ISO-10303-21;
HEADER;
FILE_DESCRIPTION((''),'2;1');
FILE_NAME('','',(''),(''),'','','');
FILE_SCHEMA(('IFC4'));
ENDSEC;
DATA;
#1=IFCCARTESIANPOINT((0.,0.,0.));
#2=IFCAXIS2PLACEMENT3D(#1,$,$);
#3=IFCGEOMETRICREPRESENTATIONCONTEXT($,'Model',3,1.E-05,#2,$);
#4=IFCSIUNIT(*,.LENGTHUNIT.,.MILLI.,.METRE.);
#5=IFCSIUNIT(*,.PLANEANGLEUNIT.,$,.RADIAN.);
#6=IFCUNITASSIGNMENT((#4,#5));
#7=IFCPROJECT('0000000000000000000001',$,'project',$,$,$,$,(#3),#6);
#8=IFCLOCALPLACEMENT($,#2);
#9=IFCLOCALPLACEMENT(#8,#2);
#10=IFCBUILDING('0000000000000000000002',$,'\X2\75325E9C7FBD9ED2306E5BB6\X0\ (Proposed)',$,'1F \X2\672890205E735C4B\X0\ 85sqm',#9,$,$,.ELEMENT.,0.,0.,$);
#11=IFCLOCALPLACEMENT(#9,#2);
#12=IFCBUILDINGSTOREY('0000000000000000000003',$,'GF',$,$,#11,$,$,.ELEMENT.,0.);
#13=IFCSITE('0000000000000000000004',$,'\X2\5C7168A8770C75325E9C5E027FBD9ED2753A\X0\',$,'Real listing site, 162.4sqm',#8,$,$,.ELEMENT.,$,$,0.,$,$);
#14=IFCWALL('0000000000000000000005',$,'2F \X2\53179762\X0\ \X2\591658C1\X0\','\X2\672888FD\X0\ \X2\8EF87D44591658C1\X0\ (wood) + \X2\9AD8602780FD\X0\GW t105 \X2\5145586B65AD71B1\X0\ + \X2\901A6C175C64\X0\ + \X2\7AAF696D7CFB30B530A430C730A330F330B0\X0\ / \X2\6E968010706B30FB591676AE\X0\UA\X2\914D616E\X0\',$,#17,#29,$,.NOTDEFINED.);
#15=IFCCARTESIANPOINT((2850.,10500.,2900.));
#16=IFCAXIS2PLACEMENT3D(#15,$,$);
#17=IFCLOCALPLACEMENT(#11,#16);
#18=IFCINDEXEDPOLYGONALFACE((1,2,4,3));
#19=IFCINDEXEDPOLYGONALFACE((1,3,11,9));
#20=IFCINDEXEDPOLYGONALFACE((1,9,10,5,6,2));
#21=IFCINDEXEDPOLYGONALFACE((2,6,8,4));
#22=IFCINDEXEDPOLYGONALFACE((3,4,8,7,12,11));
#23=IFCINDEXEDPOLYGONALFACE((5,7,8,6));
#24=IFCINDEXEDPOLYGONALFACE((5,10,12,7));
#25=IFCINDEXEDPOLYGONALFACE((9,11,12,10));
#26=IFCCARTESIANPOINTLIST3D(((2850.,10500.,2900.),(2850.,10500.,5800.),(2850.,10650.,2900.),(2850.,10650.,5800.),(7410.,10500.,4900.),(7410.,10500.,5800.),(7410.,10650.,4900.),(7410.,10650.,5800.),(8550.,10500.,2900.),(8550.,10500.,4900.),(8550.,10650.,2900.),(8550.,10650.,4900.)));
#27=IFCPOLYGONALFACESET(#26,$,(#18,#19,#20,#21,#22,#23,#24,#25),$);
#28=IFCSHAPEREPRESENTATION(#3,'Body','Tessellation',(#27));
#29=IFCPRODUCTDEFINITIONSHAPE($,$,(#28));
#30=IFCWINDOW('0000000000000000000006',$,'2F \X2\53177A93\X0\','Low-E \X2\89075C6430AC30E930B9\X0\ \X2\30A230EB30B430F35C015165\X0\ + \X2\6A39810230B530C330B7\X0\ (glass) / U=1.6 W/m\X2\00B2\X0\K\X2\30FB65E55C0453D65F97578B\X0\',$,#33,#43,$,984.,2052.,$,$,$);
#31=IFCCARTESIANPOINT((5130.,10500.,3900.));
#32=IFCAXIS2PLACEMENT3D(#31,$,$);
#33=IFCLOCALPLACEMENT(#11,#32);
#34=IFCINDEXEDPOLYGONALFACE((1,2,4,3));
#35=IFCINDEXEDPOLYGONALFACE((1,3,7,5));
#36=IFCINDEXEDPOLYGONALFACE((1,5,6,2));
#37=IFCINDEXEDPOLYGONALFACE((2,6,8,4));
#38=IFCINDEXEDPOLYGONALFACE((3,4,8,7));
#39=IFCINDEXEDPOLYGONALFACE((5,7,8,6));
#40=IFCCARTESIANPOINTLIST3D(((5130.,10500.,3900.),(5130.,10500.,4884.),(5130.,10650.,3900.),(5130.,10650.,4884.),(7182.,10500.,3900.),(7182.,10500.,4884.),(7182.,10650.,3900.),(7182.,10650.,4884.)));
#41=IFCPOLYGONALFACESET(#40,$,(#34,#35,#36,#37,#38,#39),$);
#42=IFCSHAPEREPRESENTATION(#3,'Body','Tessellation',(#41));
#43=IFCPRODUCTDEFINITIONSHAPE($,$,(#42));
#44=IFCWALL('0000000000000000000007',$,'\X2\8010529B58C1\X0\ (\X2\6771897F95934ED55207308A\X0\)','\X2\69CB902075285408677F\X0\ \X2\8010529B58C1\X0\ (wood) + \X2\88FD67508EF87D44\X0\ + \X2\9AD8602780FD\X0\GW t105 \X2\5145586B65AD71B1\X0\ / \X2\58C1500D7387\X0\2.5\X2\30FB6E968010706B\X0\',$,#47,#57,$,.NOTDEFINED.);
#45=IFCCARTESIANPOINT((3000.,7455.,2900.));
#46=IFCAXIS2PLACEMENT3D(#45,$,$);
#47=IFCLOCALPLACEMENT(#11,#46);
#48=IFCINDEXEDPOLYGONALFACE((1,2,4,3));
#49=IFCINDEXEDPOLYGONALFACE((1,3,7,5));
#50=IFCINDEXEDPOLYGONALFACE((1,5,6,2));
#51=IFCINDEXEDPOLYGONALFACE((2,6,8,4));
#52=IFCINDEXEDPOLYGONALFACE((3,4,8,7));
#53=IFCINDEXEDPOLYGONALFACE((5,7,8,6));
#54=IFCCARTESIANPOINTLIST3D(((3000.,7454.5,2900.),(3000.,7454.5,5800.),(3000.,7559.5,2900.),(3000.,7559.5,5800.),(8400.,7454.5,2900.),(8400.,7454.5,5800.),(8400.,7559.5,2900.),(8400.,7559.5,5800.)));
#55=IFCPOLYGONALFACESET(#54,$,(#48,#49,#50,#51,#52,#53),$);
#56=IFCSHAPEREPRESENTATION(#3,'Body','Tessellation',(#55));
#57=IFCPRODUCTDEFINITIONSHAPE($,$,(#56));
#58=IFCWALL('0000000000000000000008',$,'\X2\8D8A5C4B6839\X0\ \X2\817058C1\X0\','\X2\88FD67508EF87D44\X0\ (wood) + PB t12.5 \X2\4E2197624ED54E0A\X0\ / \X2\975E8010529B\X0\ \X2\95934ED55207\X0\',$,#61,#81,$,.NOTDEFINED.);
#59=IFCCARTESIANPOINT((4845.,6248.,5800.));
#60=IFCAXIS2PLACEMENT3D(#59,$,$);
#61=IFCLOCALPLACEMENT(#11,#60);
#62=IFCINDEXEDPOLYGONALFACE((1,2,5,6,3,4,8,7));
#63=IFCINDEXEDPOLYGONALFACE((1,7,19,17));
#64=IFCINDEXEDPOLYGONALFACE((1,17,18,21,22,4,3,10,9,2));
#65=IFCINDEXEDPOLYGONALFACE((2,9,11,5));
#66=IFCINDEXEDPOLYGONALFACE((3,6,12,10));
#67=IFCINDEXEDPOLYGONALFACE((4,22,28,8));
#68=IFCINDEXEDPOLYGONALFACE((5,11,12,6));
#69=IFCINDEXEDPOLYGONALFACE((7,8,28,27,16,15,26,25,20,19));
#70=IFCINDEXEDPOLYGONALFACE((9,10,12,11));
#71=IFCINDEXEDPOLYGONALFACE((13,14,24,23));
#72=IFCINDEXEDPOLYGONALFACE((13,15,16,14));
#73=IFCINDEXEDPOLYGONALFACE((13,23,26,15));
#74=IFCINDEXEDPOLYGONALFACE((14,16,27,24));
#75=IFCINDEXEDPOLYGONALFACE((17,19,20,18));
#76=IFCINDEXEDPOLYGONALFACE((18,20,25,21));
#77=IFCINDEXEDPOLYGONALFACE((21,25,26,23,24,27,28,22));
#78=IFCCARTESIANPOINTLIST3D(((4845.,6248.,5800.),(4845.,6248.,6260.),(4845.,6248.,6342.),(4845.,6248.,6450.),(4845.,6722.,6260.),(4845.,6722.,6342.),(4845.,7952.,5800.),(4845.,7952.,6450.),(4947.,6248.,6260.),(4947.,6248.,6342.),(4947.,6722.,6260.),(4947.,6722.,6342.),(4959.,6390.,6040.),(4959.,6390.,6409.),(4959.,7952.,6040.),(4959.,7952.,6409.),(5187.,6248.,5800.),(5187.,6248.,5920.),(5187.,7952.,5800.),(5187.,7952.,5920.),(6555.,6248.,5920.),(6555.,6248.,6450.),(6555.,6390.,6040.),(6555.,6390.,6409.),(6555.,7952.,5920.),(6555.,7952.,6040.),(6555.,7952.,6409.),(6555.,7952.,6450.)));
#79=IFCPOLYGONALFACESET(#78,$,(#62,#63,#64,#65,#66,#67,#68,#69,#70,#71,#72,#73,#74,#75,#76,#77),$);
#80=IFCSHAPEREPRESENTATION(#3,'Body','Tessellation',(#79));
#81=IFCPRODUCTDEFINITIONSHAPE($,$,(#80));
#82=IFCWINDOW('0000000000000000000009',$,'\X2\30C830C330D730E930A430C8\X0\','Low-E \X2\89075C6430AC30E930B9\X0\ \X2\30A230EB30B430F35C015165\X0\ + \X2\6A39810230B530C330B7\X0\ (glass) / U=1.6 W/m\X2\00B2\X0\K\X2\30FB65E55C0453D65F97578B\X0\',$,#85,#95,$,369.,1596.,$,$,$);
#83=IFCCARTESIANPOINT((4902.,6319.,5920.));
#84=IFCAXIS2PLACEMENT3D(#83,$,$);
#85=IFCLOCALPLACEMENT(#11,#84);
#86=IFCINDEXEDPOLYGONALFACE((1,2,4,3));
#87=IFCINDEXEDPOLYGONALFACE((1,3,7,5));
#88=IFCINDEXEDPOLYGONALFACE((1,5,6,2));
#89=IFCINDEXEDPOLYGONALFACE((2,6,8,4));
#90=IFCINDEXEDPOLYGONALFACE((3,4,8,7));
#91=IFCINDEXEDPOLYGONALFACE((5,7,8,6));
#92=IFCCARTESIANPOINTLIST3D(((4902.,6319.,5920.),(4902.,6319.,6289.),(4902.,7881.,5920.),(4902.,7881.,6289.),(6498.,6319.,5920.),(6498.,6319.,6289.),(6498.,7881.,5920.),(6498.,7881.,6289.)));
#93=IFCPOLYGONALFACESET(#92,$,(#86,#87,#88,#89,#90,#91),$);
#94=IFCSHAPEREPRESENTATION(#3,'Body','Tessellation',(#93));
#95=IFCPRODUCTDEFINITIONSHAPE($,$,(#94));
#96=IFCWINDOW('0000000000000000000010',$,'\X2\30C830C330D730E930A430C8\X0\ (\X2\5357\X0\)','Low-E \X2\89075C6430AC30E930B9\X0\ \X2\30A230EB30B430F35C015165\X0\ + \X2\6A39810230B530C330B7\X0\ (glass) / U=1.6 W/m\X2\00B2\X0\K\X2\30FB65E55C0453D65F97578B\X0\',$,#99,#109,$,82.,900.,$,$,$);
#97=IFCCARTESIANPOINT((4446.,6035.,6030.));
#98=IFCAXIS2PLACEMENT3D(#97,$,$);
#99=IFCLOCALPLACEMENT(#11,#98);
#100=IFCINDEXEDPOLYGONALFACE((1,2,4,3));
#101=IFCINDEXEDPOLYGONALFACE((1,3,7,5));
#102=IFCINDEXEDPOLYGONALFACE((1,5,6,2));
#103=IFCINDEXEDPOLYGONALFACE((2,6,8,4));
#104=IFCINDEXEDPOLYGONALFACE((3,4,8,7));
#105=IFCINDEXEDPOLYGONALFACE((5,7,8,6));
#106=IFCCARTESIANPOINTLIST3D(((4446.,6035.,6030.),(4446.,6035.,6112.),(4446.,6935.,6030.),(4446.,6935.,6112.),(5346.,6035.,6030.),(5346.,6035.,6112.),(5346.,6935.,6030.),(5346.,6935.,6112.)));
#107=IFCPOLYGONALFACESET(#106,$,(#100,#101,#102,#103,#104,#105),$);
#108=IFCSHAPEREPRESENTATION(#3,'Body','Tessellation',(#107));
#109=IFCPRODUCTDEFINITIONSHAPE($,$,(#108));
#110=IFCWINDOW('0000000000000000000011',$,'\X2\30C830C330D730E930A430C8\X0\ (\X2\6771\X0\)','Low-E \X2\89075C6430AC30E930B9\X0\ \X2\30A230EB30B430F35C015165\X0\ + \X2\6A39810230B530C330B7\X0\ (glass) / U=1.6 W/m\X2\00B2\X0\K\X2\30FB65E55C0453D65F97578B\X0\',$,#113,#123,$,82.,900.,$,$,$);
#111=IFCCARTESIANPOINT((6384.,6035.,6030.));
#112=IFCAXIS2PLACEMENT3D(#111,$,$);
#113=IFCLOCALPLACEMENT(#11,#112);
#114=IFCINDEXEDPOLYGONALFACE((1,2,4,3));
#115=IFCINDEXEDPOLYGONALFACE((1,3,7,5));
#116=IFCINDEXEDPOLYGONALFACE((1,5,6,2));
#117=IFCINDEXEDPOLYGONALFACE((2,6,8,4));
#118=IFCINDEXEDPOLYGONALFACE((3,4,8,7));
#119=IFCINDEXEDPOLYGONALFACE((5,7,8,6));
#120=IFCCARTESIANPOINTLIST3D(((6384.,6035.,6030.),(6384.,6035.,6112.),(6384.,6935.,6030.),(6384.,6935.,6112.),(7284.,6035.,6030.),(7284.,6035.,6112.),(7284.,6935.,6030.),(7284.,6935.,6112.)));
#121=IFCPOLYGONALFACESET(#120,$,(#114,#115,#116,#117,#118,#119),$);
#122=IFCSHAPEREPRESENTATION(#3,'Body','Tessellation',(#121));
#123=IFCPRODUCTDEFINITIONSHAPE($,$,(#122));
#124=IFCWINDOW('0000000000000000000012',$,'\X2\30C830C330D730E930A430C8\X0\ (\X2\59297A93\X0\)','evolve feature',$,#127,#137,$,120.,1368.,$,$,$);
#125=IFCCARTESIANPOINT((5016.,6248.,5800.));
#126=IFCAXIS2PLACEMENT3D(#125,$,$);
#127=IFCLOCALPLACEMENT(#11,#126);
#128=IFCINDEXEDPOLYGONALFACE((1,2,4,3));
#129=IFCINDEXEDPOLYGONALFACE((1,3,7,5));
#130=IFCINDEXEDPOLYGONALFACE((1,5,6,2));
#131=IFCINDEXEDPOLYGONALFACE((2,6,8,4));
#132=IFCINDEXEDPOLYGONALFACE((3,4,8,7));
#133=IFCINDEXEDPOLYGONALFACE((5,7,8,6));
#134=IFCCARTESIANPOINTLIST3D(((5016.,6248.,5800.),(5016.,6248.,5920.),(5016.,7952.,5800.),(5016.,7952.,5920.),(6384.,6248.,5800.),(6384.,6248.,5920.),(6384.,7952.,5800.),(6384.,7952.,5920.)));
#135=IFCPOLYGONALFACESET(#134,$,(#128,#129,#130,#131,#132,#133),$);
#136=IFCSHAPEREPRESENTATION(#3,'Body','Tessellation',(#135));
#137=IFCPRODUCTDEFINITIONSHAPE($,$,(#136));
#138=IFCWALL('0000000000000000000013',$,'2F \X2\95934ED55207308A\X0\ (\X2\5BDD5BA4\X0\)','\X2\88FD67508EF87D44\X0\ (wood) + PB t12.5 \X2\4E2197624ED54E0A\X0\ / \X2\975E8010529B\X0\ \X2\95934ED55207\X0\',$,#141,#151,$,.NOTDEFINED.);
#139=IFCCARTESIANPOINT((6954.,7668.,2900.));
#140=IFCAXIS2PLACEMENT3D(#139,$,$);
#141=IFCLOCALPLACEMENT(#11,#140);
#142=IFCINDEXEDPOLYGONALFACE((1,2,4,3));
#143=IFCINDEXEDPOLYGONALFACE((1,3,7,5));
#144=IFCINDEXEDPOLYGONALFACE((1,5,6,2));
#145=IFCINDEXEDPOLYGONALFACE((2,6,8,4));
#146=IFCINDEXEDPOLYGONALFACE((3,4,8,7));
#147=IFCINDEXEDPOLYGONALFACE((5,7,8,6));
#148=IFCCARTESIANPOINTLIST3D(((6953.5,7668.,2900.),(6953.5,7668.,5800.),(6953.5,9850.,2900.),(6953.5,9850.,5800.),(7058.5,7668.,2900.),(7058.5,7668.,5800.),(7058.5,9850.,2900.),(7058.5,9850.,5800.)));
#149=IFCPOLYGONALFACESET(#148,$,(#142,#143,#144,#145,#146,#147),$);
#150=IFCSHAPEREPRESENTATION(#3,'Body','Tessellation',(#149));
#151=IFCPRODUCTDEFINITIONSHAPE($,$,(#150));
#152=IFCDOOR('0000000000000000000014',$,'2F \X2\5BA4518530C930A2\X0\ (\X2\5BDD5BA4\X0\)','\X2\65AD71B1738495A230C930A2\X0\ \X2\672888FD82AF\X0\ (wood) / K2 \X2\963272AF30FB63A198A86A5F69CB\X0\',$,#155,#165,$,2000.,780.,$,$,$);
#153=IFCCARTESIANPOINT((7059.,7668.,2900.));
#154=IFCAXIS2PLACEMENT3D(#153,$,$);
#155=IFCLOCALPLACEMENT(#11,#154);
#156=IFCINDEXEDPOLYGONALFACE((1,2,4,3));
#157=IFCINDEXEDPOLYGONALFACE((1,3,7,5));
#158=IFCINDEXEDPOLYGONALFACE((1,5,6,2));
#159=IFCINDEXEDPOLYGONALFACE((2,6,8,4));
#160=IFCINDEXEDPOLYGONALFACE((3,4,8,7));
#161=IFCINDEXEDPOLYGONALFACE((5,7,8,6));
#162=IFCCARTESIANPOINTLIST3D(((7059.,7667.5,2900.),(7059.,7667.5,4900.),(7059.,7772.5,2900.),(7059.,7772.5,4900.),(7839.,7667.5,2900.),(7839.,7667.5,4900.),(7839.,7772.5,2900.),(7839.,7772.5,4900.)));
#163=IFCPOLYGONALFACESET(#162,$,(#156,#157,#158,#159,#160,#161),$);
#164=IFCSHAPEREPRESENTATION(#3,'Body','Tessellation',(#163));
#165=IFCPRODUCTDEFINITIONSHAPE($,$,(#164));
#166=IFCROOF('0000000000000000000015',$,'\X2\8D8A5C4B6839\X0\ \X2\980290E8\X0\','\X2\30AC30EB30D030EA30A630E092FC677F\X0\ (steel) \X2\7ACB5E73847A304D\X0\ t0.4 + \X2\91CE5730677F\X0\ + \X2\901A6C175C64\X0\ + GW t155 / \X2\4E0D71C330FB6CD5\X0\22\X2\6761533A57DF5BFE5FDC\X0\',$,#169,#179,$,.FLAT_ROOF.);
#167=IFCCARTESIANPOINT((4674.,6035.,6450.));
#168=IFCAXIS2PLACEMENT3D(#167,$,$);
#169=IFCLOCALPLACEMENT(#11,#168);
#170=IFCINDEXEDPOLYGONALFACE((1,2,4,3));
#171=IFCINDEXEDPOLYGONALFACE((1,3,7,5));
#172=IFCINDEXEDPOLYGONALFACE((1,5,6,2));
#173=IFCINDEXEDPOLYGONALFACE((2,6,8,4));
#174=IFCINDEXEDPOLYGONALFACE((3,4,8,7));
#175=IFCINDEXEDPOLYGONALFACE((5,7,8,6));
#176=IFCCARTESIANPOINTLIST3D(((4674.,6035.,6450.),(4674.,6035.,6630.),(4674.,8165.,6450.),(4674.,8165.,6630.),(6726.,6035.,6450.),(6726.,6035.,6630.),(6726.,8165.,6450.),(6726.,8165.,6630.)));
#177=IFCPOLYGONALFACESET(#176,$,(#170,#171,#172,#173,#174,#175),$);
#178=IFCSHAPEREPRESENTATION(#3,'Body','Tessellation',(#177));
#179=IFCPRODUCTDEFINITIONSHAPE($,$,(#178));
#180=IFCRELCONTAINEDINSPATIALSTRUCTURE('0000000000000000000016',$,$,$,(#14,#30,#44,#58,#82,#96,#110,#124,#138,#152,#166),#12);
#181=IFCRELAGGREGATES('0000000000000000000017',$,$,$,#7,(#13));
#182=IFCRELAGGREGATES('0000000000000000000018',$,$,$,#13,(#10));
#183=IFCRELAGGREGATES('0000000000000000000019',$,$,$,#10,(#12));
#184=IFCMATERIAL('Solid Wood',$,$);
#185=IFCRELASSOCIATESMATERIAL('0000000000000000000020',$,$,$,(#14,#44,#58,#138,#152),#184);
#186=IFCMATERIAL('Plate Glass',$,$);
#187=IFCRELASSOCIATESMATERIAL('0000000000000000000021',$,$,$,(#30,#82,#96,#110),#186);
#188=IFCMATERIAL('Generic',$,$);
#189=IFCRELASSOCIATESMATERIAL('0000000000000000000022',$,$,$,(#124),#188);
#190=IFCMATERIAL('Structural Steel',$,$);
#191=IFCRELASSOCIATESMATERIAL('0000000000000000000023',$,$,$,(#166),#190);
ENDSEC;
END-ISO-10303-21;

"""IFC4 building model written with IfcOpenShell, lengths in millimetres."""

from ifc_helpers import new_model, si_unit, frame, frame_2d, origin, place, context, project, spatial, rectangle, extrude, material, element, fill, save


model = new_model("IFC4")

# Units and contexts
model_context = context("Model", 3, precision=1e-05, world=origin())
ifc_project = project(units=[si_unit("LENGTHUNIT", "METRE", prefix="MILLI"), si_unit("PLANEANGLEUNIT", "RADIAN")], contexts=[model_context])

# Site, building, storey
site_placement = place(None, origin())
site = spatial("IfcSite", under=ifc_project, at=site_placement, Name="山梨県甲府市羽黒町", ObjectType="Real listing site, 162.4sqm", CompositionType="ELEMENT", RefElevation=0.0)
building_placement = place(site_placement, origin())
building = spatial("IfcBuilding", under=site, at=building_placement, Name="甲府羽黒の家 (Proposed)", ObjectType="1F 木造平屋 85sqm", CompositionType="ELEMENT", ElevationOfRefHeight=0.0, ElevationOfTerrain=0.0)
storey_placement = place(building_placement, origin())
storey = spatial("IfcBuildingStorey", under=building, at=storey_placement, Name="GF", CompositionType="ELEMENT", Elevation=0.0)

# Wall, opening, window
ifc_material_1 = material(Name="Solid Wood")
wall_1_placement = place(storey_placement, frame((2850.0, 10500.0, 2900.0)))
wall_1 = element("IfcWall", 1, at=wall_1_placement, inside=storey, material=ifc_material_1, Name="2F 北面 外壁", Description="木製 軸組外壁 (wood) + 高性能GW t105 充填断熱 + 通気層 + 窯業系サイディング / 準耐火・外皮UA配慮", PredefinedType="NOTDEFINED", context=model_context, shape_type="SweptSolid", body=[
    extrude(rectangle(XDim=5700.0, YDim=150.0, at=frame_2d((2850.0, 75.0))), frame((2850.0, 10500.0, 2900.0)), (0.0, 0.0, 1.0), 2900.0),
])
opening_1_placement = place(storey_placement, frame((5130.0, 10500.0, 3900.0)))
opening_1 = element("IfcOpeningElement", 2, at=opening_1_placement, cuts=wall_1, PredefinedType="NOTDEFINED", context=model_context, shape_type="SweptSolid", body=[
    extrude(rectangle(XDim=2052.0, YDim=150.0, at=frame_2d((1026.0, 75.0))), frame((5130.0, 10500.0, 3900.0)), (0.0, 0.0, 1.0), 984.0),
])
ifc_material_2 = material(Name="Plate Glass")
window_1_placement = place(storey_placement, frame((5130.0, 10500.0, 3900.0)))
window_1 = element("IfcWindow", 3, at=window_1_placement, inside=storey, material=ifc_material_2, Name="2F 北窓", Description="Low-E 複層ガラス アルゴン封入 + 樹脂サッシ (glass) / U=1.6 W/m²K・日射取得型", OverallHeight=984.0, OverallWidth=2052.0, context=model_context, shape_type="SweptSolid", body=[
    extrude(rectangle(XDim=2052.0, YDim=150.0, at=frame_2d((1026.0, 75.0))), frame((5130.0, 10500.0, 3900.0)), (0.0, 0.0, 1.0), 984.0),
])
fill(opening_1, window_1)

# Wall
wall_2_placement = place(storey_placement, frame((3000.0, 7455.0, 2900.0)))
element("IfcWall", 4, at=wall_2_placement, inside=storey, material=ifc_material_1, Name="耐力壁 (東西間仕切り)", Description="構造用合板 耐力壁 (wood) + 製材軸組 + 高性能GW t105 充填断熱 / 壁倍率2.5・準耐火", PredefinedType="NOTDEFINED", context=model_context, shape_type="SweptSolid", body=[
    extrude(rectangle(XDim=5400.0, YDim=105.0, at=frame_2d((2700.0, 52.0))), frame((3000.0, 7455.0, 2900.0)), (0.0, 0.0, 1.0), 2900.0),
])

# Wall, openings, windows
wall_3_placement = place(storey_placement, frame((4845.0, 6248.0, 5800.0)))
wall_3 = element("IfcWall", 5, at=wall_3_placement, inside=storey, material=ifc_material_1, Name="越屋根 腰壁", Description="製材軸組 (wood) + PB t12.5 両面仕上 / 非耐力 間仕切", PredefinedType="NOTDEFINED", context=model_context, shape_type="SweptSolid", body=[
    extrude(rectangle(XDim=1710.0, YDim=1704.0, at=frame_2d((855.0, 852.0))), frame((4845.0, 6248.0, 5800.0)), (0.0, 0.0, 1.0), 650.0),
])
opening_2_placement = place(storey_placement, frame((4902.0, 6319.0, 5920.0)))
opening_2 = element("IfcOpeningElement", 6, at=opening_2_placement, cuts=wall_3, PredefinedType="NOTDEFINED", context=model_context, shape_type="SweptSolid", body=[
    extrude(rectangle(XDim=1596.0, YDim=1562.0, at=frame_2d((798.0, 781.0))), frame((4902.0, 6319.0, 5920.0)), (0.0, 0.0, 1.0), 369.0),
])
opening_3_placement = place(storey_placement, frame((4446.0, 6035.0, 6030.0)))
opening_3 = element("IfcOpeningElement", 7, at=opening_3_placement, cuts=wall_3, PredefinedType="NOTDEFINED", context=model_context, shape_type="SweptSolid", body=[
    extrude(rectangle(XDim=900.0, YDim=900.0, at=frame_2d((450.0, 450.0))), frame((4446.0, 6035.0, 6030.0)), (0.0, 0.0, 1.0), 82.0),
])
opening_4_placement = place(storey_placement, frame((6384.0, 6035.0, 6030.0)))
opening_4 = element("IfcOpeningElement", 8, at=opening_4_placement, cuts=wall_3, PredefinedType="NOTDEFINED", context=model_context, shape_type="SweptSolid", body=[
    extrude(rectangle(XDim=900.0, YDim=900.0, at=frame_2d((450.0, 450.0))), frame((6384.0, 6035.0, 6030.0)), (0.0, 0.0, 1.0), 82.0),
])
opening_5_placement = place(storey_placement, frame((5016.0, 6248.0, 5800.0)))
opening_5 = element("IfcOpeningElement", 9, at=opening_5_placement, cuts=wall_3, PredefinedType="NOTDEFINED", context=model_context, shape_type="SweptSolid", body=[
    extrude(rectangle(XDim=1368.0, YDim=1704.0, at=frame_2d((684.0, 852.0))), frame((5016.0, 6248.0, 5800.0)), (0.0, 0.0, 1.0), 120.0),
])
window_2_placement = place(storey_placement, frame((4902.0, 6319.0, 5920.0)))
window_2 = element("IfcWindow", 10, at=window_2_placement, inside=storey, material=ifc_material_2, Name="トップライト", Description="Low-E 複層ガラス アルゴン封入 + 樹脂サッシ (glass) / U=1.6 W/m²K・日射取得型", OverallHeight=369.0, OverallWidth=1596.0, context=model_context, shape_type="SweptSolid", body=[
    extrude(rectangle(XDim=1596.0, YDim=1562.0, at=frame_2d((798.0, 781.0))), frame((4902.0, 6319.0, 5920.0)), (0.0, 0.0, 1.0), 369.0),
])
fill(opening_2, window_2)
window_3_placement = place(storey_placement, frame((4446.0, 6035.0, 6030.0)))
window_3 = element("IfcWindow", 11, at=window_3_placement, inside=storey, material=ifc_material_2, Name="トップライト (南)", Description="Low-E 複層ガラス アルゴン封入 + 樹脂サッシ (glass) / U=1.6 W/m²K・日射取得型", OverallHeight=82.0, OverallWidth=900.0, context=model_context, shape_type="SweptSolid", body=[
    extrude(rectangle(XDim=900.0, YDim=900.0, at=frame_2d((450.0, 450.0))), frame((4446.0, 6035.0, 6030.0)), (0.0, 0.0, 1.0), 82.0),
])
fill(opening_3, window_3)
window_4_placement = place(storey_placement, frame((6384.0, 6035.0, 6030.0)))
window_4 = element("IfcWindow", 12, at=window_4_placement, inside=storey, material=ifc_material_2, Name="トップライト (東)", Description="Low-E 複層ガラス アルゴン封入 + 樹脂サッシ (glass) / U=1.6 W/m²K・日射取得型", OverallHeight=82.0, OverallWidth=900.0, context=model_context, shape_type="SweptSolid", body=[
    extrude(rectangle(XDim=900.0, YDim=900.0, at=frame_2d((450.0, 450.0))), frame((6384.0, 6035.0, 6030.0)), (0.0, 0.0, 1.0), 82.0),
])
fill(opening_4, window_4)
ifc_material_3 = material(Name="Generic")
window_5_placement = place(storey_placement, frame((5016.0, 6248.0, 5800.0)))
window_5 = element("IfcWindow", 13, at=window_5_placement, inside=storey, material=ifc_material_3, Name="トップライト (天窓)", Description="evolve feature", OverallHeight=120.0, OverallWidth=1368.0, context=model_context, shape_type="SweptSolid", body=[
    extrude(rectangle(XDim=1368.0, YDim=1704.0, at=frame_2d((684.0, 852.0))), frame((5016.0, 6248.0, 5800.0)), (0.0, 0.0, 1.0), 120.0),
])
fill(opening_5, window_5)

# Wall
wall_4_placement = place(storey_placement, frame((6954.0, 7668.0, 2900.0)))
element("IfcWall", 14, at=wall_4_placement, inside=storey, material=ifc_material_1, Name="2F 間仕切り (寝室)", Description="製材軸組 (wood) + PB t12.5 両面仕上 / 非耐力 間仕切", PredefinedType="NOTDEFINED", context=model_context, shape_type="SweptSolid", body=[
    extrude(rectangle(XDim=105.0, YDim=2182.0, at=frame_2d((52.0, 1091.0))), frame((6954.0, 7668.0, 2900.0)), (0.0, 0.0, 1.0), 2900.0),
])

# Door
door_placement = place(storey_placement, frame((7059.0, 7668.0, 2900.0)))
element("IfcDoor", 15, at=door_placement, inside=storey, material=ifc_material_1, Name="2F 室内ドア (寝室)", Description="断熱玄関ドア 木製芯 (wood) / K2 防犯・採風機構", OverallHeight=2000.0, OverallWidth=780.0, context=model_context, shape_type="SweptSolid", body=[
    extrude(rectangle(XDim=780.0, YDim=105.0, at=frame_2d((390.0, 52.0))), frame((7059.0, 7668.0, 2900.0)), (0.0, 0.0, 1.0), 2000.0),
])

# Roof
ifc_material_4 = material(Name="Structural Steel")
roof_placement = place(storey_placement, frame((4674.0, 6035.0, 6450.0)))
element("IfcRoof", 16, at=roof_placement, inside=storey, material=ifc_material_4, Name="越屋根 頂部", Description="ガルバリウム鋼板 (steel) 立平葺き t0.4 + 野地板 + 通気層 + GW t155 / 不燃・法22条区域対応", PredefinedType="FLAT_ROOF", context=model_context, shape_type="SweptSolid", body=[
    extrude(rectangle(XDim=2052.0, YDim=2130.0, at=frame_2d((1026.0, 1065.0))), frame((4674.0, 6035.0, 6450.0)), (0.0, 0.0, 1.0), 180.0),
])

save(model, "model.ifc")
